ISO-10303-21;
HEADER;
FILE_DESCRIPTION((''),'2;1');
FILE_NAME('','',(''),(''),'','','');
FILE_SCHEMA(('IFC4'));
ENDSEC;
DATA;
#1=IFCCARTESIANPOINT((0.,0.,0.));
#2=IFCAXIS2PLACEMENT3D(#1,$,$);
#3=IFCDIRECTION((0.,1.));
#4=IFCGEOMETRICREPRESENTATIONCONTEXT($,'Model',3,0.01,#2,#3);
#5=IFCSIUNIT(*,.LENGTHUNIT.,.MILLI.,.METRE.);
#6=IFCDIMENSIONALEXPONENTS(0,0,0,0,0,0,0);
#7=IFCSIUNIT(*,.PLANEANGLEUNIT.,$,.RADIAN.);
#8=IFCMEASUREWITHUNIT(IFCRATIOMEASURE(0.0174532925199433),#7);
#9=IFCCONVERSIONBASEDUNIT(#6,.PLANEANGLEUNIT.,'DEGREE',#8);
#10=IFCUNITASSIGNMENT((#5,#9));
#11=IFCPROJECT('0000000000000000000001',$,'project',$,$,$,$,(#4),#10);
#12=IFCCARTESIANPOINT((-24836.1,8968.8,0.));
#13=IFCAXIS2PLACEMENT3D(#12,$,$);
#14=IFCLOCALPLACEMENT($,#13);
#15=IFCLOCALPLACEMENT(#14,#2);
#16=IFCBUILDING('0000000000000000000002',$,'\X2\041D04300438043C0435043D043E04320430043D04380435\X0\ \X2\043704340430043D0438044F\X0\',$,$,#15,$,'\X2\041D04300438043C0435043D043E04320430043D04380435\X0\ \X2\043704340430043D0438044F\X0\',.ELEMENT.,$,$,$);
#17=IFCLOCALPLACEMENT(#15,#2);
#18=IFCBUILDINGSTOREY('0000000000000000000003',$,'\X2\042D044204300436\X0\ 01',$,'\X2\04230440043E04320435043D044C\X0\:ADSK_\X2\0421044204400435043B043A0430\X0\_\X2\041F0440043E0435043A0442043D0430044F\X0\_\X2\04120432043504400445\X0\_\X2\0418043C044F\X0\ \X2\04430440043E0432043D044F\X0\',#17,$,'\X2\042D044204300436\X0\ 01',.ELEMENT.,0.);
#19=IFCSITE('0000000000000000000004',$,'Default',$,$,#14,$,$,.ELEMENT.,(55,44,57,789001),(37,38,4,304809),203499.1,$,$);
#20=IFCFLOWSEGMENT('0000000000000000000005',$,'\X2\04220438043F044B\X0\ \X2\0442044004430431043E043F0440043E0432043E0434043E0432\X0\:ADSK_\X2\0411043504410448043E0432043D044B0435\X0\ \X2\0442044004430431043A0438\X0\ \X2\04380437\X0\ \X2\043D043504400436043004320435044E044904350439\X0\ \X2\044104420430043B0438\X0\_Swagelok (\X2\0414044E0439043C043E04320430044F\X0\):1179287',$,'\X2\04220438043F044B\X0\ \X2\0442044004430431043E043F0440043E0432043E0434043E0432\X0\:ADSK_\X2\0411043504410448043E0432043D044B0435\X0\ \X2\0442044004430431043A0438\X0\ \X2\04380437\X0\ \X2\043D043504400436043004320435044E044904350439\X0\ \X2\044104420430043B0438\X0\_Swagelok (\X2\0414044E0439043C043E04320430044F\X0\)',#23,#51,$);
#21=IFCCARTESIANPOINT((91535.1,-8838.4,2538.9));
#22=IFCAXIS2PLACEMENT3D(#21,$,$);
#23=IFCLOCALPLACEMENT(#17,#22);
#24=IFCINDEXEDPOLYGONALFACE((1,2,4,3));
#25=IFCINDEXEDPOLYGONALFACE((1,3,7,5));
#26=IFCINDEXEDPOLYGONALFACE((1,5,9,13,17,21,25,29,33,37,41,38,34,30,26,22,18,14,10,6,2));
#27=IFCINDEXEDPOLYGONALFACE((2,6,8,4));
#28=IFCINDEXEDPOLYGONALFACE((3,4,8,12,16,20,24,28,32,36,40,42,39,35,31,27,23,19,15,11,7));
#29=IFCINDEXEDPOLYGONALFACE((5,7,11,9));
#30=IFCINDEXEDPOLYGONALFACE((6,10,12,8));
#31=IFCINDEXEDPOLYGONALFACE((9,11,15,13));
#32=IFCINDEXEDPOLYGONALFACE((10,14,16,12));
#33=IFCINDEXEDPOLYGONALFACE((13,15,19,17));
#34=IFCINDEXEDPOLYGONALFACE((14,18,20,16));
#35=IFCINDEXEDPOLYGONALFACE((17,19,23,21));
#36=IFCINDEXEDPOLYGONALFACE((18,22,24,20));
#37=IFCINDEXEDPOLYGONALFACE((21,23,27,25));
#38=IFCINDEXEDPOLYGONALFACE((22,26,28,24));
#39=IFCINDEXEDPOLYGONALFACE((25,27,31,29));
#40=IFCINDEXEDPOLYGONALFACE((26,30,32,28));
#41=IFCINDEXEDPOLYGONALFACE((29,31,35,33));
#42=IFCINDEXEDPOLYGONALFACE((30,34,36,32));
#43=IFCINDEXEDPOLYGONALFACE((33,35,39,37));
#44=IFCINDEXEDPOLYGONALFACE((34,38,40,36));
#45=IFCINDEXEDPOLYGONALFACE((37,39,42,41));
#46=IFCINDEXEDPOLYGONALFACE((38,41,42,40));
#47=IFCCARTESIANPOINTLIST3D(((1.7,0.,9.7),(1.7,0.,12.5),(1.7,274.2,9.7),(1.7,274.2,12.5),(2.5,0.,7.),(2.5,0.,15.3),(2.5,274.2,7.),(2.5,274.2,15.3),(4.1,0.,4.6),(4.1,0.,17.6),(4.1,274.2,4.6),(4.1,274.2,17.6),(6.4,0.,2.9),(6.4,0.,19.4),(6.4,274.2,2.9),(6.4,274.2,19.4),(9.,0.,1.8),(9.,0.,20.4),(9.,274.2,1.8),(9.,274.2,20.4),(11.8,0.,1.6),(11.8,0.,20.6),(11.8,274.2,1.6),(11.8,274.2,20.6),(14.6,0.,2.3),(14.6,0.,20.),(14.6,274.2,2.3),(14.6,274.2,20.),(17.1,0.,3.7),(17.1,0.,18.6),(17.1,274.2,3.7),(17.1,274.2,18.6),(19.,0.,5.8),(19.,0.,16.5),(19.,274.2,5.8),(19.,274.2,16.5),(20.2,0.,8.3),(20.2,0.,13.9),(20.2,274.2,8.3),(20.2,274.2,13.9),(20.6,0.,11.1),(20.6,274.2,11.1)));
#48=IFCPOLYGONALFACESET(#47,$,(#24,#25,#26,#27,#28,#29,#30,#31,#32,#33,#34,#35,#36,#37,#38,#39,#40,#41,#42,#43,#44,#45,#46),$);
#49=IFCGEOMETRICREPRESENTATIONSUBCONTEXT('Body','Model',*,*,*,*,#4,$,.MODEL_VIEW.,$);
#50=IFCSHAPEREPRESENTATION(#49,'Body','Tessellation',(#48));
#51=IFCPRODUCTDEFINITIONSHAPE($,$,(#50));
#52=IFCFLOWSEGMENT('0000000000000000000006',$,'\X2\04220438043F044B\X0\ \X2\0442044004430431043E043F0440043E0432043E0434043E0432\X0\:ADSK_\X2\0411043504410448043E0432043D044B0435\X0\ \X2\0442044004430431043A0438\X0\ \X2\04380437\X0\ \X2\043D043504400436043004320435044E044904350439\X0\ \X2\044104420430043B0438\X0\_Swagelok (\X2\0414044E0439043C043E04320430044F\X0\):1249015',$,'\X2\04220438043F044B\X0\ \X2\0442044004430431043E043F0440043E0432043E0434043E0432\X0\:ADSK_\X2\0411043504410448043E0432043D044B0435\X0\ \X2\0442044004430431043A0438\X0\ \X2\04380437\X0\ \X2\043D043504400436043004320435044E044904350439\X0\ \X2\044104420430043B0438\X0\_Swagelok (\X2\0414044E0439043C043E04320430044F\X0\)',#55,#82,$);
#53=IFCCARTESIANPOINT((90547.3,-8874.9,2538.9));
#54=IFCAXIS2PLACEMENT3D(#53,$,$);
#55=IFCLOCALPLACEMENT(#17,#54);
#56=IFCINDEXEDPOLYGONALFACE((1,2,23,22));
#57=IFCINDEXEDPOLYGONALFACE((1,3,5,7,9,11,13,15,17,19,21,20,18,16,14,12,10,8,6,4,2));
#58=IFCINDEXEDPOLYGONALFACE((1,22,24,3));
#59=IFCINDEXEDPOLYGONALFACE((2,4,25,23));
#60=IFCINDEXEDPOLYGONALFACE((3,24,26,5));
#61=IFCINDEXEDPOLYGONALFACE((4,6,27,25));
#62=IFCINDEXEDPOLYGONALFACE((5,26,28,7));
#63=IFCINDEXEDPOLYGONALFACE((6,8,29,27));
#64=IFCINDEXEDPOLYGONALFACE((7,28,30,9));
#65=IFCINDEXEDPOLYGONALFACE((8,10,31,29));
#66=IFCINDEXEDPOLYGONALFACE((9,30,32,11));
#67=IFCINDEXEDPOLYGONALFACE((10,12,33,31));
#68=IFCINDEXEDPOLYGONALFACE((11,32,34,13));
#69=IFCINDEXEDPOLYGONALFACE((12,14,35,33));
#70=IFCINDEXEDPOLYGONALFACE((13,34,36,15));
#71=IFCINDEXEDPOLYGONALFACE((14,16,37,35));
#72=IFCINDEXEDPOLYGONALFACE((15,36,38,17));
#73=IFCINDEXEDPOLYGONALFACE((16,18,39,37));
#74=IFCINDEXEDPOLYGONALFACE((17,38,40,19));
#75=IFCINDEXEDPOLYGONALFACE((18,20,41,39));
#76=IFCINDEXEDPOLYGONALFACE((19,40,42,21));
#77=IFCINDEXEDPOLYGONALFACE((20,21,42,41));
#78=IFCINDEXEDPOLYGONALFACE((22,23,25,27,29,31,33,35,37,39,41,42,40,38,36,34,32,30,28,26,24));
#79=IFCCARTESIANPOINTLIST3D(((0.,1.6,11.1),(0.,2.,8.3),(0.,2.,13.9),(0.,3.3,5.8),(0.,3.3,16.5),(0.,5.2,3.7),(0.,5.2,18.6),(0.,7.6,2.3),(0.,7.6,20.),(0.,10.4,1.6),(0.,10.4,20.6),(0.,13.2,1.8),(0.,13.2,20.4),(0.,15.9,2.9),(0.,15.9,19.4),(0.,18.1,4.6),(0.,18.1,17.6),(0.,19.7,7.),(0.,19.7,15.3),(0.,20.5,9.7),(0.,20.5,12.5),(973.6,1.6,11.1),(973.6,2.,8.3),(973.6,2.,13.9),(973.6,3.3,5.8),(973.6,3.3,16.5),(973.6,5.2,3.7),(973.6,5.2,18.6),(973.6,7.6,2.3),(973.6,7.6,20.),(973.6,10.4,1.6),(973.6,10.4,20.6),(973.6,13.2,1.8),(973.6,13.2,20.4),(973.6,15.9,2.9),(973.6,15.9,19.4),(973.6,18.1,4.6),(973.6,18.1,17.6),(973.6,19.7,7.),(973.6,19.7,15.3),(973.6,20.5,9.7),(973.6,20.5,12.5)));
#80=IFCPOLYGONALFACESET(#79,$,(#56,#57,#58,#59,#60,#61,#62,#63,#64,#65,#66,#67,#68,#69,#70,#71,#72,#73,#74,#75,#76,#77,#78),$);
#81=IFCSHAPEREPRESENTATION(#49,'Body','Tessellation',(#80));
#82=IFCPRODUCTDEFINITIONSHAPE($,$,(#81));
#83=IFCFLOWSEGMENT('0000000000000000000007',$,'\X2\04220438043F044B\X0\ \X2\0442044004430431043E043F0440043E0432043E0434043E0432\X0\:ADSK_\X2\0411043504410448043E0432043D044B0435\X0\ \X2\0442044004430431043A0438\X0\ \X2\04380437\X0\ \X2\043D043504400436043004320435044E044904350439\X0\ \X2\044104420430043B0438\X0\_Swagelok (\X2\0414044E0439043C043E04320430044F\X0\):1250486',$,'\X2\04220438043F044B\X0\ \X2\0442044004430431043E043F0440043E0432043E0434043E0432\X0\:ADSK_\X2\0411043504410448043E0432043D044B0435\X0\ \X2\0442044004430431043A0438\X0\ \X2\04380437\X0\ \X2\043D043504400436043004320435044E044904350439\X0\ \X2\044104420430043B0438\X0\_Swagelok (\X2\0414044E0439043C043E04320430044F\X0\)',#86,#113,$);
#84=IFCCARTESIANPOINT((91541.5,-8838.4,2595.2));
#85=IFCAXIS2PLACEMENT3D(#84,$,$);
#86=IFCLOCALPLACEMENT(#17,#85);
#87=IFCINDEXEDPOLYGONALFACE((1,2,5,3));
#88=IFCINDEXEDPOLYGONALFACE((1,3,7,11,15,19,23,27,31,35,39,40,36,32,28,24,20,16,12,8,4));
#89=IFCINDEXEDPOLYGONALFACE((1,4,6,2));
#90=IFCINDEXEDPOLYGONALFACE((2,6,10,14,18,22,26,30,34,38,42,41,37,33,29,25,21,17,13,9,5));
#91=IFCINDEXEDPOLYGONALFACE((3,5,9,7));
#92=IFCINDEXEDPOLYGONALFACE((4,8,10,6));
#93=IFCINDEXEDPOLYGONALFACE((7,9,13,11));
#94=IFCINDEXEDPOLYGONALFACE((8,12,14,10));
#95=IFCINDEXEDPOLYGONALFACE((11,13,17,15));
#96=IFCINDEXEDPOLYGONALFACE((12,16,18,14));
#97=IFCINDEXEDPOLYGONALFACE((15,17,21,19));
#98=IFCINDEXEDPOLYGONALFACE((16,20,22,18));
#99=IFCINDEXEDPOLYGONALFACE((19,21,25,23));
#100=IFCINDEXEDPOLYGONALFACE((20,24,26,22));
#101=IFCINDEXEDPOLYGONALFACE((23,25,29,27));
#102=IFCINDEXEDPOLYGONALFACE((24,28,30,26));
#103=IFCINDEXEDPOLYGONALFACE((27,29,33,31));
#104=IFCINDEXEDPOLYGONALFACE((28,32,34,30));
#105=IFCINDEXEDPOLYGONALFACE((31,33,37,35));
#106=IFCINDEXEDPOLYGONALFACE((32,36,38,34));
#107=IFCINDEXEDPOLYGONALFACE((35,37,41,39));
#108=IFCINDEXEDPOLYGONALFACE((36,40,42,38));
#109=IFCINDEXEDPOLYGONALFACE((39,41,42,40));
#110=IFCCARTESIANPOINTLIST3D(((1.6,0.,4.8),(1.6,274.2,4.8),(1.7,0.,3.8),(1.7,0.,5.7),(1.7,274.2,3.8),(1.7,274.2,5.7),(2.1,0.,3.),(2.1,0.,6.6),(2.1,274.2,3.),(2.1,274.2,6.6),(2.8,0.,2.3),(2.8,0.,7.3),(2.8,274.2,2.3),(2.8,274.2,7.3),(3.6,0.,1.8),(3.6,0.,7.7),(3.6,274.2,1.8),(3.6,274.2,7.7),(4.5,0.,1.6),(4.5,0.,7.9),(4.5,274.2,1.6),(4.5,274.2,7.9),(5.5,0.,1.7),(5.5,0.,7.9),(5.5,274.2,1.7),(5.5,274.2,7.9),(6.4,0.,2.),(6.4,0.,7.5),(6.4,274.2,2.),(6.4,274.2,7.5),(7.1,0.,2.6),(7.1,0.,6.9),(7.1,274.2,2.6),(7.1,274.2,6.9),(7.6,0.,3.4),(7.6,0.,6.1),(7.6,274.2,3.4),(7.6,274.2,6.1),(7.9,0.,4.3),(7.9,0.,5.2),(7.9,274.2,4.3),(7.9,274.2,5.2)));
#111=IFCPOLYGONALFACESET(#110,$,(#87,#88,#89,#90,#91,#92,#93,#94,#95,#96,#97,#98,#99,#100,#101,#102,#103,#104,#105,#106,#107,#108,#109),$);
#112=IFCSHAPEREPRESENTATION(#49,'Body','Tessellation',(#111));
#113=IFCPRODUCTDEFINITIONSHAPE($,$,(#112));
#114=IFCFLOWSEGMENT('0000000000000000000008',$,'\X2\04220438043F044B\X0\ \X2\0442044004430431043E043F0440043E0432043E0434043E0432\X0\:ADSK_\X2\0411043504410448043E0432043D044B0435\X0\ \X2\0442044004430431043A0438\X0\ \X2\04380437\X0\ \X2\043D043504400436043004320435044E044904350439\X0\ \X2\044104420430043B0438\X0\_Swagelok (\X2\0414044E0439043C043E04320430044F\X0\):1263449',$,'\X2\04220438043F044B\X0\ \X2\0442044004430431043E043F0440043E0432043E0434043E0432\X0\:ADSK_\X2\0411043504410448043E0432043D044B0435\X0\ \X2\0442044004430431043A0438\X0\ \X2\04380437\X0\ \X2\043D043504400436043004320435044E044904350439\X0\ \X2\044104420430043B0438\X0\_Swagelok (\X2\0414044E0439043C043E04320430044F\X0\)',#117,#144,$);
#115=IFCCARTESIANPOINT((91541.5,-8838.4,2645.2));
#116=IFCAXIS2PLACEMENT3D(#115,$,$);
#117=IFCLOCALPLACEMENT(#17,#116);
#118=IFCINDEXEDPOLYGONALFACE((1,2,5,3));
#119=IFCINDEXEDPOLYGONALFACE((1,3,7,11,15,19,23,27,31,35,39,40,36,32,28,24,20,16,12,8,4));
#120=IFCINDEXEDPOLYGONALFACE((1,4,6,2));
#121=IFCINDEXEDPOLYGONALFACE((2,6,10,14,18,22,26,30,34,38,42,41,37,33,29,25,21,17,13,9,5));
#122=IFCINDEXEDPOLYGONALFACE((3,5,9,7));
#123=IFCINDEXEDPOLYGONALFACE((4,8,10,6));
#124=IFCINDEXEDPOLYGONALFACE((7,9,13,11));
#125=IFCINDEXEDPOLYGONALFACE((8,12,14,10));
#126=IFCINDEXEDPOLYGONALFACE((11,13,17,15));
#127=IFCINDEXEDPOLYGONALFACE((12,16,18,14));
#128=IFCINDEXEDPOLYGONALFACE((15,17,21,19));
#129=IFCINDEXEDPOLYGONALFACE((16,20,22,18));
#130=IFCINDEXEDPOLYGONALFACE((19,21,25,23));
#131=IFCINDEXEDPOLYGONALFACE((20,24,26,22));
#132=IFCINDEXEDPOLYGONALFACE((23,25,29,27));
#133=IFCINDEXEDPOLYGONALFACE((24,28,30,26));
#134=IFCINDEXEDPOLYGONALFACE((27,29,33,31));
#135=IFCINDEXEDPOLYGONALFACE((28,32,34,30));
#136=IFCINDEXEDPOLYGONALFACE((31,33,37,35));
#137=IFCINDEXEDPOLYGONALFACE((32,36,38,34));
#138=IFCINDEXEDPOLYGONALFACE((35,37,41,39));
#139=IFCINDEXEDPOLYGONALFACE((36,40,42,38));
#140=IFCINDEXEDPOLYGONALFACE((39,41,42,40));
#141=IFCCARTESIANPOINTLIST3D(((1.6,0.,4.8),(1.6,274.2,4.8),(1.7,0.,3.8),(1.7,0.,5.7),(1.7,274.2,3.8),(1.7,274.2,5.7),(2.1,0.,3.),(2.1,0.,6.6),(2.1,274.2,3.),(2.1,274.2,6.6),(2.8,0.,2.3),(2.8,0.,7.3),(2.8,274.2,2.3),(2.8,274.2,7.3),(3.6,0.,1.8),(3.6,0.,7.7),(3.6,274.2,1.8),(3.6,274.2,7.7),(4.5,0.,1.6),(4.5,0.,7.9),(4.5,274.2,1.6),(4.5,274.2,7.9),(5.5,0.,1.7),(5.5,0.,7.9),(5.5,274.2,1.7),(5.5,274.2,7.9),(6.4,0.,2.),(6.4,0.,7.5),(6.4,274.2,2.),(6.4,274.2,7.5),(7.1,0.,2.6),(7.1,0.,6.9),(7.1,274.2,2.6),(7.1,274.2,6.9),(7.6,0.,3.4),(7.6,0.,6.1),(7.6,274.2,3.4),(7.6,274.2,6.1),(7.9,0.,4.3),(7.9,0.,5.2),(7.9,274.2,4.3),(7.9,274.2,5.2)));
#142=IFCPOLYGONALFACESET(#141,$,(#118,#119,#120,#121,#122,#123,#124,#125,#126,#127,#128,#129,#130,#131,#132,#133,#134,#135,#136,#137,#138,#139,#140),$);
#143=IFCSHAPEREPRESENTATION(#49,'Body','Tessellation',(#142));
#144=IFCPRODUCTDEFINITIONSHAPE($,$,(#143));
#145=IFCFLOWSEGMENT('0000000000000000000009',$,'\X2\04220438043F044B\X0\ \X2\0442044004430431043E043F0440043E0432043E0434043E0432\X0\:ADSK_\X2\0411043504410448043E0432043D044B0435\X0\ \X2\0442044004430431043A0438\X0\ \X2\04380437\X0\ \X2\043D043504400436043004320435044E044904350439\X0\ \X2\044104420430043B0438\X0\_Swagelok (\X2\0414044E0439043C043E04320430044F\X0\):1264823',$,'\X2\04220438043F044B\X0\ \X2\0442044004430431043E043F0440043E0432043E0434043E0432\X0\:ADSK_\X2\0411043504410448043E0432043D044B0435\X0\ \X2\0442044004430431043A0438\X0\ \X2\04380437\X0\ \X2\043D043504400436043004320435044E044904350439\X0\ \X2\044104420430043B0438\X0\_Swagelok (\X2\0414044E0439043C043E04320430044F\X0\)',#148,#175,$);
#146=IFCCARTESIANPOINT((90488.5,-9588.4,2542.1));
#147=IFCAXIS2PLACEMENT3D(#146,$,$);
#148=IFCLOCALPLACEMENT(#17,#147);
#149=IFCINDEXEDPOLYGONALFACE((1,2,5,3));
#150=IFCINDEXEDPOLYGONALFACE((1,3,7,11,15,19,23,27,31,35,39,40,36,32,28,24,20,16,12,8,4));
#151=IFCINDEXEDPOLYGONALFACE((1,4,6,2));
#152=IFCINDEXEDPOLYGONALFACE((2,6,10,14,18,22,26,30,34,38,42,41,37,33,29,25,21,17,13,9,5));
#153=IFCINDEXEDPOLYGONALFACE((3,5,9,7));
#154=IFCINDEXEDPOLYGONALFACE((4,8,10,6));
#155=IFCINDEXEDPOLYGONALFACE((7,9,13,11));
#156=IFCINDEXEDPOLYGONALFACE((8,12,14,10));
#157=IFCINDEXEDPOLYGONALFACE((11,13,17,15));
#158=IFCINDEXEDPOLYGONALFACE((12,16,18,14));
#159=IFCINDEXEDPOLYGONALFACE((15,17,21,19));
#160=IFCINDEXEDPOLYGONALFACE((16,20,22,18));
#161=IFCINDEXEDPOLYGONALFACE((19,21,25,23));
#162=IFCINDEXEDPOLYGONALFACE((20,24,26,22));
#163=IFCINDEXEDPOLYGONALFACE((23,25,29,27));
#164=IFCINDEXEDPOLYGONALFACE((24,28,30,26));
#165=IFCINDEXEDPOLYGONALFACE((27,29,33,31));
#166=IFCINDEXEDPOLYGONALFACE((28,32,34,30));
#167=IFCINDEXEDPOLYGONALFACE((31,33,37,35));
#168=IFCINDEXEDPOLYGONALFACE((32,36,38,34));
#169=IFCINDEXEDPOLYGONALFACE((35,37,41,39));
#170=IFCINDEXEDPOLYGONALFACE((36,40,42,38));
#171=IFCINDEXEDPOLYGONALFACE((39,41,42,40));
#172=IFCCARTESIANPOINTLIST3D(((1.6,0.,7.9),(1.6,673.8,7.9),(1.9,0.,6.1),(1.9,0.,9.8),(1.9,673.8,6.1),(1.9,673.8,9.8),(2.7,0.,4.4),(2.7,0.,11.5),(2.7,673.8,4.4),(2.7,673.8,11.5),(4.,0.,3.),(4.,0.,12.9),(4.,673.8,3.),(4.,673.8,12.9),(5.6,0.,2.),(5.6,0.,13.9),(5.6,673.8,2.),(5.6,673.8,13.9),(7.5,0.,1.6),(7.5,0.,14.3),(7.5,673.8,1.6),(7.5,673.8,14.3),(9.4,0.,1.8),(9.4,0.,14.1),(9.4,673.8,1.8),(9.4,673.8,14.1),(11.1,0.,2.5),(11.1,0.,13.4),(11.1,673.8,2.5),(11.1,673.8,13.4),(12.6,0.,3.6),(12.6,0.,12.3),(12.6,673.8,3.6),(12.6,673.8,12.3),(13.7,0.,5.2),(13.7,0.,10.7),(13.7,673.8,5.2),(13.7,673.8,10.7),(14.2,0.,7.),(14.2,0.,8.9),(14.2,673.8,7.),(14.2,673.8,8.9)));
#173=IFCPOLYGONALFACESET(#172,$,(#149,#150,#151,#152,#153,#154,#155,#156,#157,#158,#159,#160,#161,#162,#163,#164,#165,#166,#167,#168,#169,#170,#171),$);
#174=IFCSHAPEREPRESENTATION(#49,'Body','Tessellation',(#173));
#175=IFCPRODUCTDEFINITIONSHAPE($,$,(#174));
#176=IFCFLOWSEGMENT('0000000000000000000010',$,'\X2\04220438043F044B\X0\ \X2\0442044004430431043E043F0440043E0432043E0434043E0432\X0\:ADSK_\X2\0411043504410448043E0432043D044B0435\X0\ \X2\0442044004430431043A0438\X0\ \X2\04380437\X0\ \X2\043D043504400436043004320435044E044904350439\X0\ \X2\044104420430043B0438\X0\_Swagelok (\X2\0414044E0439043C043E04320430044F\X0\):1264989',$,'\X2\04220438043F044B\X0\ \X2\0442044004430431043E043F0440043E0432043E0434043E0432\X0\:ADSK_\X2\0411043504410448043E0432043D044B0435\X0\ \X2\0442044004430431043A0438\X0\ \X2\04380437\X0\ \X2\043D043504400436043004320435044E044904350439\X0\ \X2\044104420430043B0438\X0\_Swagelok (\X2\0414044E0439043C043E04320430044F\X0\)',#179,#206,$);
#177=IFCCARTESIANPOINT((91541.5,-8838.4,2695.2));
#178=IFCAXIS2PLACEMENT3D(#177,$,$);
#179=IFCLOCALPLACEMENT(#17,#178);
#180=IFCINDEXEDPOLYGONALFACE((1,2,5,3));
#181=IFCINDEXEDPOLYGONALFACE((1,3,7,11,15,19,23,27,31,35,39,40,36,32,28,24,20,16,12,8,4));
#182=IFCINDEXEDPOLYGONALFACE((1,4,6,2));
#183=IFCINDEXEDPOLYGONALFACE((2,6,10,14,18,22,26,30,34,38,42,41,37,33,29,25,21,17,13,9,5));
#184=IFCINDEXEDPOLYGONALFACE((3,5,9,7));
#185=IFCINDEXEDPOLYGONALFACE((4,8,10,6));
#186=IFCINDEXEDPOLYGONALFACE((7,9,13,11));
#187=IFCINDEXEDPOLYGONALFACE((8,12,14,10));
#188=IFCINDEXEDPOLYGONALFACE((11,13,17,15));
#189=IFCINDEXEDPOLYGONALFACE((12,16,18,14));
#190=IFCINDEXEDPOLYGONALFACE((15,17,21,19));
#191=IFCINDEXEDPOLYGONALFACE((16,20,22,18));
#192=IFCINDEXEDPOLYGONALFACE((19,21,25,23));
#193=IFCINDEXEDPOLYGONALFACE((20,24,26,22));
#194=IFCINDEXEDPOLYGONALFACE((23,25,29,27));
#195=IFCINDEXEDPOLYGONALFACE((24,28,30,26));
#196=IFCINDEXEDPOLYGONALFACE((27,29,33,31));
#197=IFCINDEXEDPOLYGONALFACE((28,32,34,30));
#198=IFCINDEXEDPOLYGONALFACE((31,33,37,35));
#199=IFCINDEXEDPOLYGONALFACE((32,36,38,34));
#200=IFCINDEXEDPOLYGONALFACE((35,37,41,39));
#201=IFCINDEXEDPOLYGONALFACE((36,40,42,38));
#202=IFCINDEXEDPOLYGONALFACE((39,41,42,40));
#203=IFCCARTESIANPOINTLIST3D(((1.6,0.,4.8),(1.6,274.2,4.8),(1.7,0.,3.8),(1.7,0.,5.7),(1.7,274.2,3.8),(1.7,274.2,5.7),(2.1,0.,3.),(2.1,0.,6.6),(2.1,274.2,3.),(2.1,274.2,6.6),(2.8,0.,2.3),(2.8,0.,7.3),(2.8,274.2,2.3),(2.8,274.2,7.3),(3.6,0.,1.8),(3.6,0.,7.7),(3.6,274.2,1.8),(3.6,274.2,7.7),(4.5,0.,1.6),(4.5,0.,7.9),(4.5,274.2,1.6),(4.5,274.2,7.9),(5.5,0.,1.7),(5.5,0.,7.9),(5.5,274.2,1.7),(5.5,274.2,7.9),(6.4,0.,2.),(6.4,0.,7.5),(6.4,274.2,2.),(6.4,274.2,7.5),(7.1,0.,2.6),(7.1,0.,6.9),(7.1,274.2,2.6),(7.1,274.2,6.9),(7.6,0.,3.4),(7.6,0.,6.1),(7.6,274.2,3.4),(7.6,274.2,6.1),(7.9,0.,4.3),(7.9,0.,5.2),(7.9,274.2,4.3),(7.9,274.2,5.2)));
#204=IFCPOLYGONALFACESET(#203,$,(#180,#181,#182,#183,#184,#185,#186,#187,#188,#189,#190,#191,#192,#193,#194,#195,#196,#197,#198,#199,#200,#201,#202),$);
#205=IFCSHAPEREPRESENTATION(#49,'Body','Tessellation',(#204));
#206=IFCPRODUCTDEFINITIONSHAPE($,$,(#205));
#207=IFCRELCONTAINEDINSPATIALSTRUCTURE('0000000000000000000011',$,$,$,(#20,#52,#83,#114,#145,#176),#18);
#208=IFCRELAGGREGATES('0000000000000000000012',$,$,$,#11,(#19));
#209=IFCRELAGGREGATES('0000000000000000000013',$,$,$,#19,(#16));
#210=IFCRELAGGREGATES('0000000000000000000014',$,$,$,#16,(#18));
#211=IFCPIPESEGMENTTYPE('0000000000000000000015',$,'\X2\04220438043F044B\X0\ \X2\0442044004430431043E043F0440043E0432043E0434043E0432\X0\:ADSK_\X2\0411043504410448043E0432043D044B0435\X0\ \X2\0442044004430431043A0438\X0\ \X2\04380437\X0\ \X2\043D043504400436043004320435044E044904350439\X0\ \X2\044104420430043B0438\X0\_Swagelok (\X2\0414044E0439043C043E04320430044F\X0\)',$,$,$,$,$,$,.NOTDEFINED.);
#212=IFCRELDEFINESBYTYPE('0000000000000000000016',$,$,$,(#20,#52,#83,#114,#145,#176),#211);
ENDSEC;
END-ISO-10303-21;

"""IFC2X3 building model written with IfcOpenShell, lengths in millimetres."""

from ifc_helpers import new_model, entity, si_unit, converted_unit, direction, frame, origin, origin_2d_with_axis, place, context, subcontext, project, spatial, circle, extrude, type_object, element, save


model = new_model("IFC2X3")

# Units and contexts
model_context = context("Model", 3, precision=0.01, world=origin(), true_north=direction((0.0, 1.0)))
body_context = subcontext(model_context, "Body", "Model", "MODEL_VIEW")
ifc_project = project(units=[si_unit("LENGTHUNIT", "METRE", prefix="MILLI"), converted_unit("PLANEANGLEUNIT", "DEGREE", entity("IfcRatioMeasure", 0.0174532925199433), si_unit("PLANEANGLEUNIT", "RADIAN"), dimensions=[0, 0, 0, 0, 0, 0, 0])], contexts=[model_context])

# Site, building, storey
site_placement = place(None, frame((-24836.1, 8968.8, 0.0)))
site = spatial("IfcSite", under=ifc_project, at=site_placement, Name="Default", CompositionType="ELEMENT", RefLatitude=(55, 44, 57, 789001), RefLongitude=(37, 38, 4, 304809), RefElevation=203499.1)
building_placement = place(site_placement, origin())
building = spatial("IfcBuilding", under=site, at=building_placement, Name="Наименование здания", LongName="Наименование здания", CompositionType="ELEMENT")
storey_placement = place(building_placement, origin())
storey = spatial("IfcBuildingStorey", under=building, at=storey_placement, Name="Этаж 01", ObjectType="Уровень:ADSK_Стрелка_Проектная_Вверх_Имя уровня", LongName="Этаж 01", CompositionType="ELEMENT", Elevation=0.0)

# Flow segments
pipe_segment_type_1 = type_object("IfcPipeSegmentType", Name="Типы трубопроводов:ADSK_Бесшовные трубки из нержавеющей стали_Swagelok (Дюймовая)", PredefinedType="NOTDEFINED")
flow_segment_1_placement = place(storey_placement, frame((91535.1, -8838.4, 2538.9)))
element("IfcFlowSegment", 1, at=flow_segment_1_placement, inside=storey, type_object=pipe_segment_type_1, Name="Типы трубопроводов:ADSK_Бесшовные трубки из нержавеющей стали_Swagelok (Дюймовая):1179287", ObjectType="Типы трубопроводов:ADSK_Бесшовные трубки из нержавеющей стали_Swagelok (Дюймовая)", context=body_context, shape_type="SweptSolid", body=[
    extrude(circle(Radius=9.5, at=origin_2d_with_axis()), frame((11.1, 0.0, 11.1), z_axis=(0.0, 1.0, 0.0), x_axis=(1.0, 0.0, 0.0)), (0.0, 0.0, 1.0), 274.2),
])
flow_segment_2_placement = place(storey_placement, frame((90547.3, -8874.9, 2538.9)))
element("IfcFlowSegment", 2, at=flow_segment_2_placement, inside=storey, type_object=pipe_segment_type_1, Name="Типы трубопроводов:ADSK_Бесшовные трубки из нержавеющей стали_Swagelok (Дюймовая):1249015", ObjectType="Типы трубопроводов:ADSK_Бесшовные трубки из нержавеющей стали_Swagelok (Дюймовая)", context=body_context, shape_type="SweptSolid", body=[
    extrude(circle(Radius=9.5, at=origin_2d_with_axis()), frame((0.0, 11.1, 11.1), z_axis=(1.0, 0.0, 0.0), x_axis=(0.0, -1.0, 0.0)), (0.0, 0.0, 1.0), 973.6),
])
flow_segment_3_placement = place(storey_placement, frame((91541.5, -8838.4, 2595.2)))
element("IfcFlowSegment", 3, at=flow_segment_3_placement, inside=storey, type_object=pipe_segment_type_1, Name="Типы трубопроводов:ADSK_Бесшовные трубки из нержавеющей стали_Swagelok (Дюймовая):1250486", ObjectType="Типы трубопроводов:ADSK_Бесшовные трубки из нержавеющей стали_Swagelok (Дюймовая)", context=body_context, shape_type="SweptSolid", body=[
    extrude(circle(Radius=3.2, at=origin_2d_with_axis()), frame((4.8, 0.0, 4.8), z_axis=(0.0, 1.0, 0.0), x_axis=(-1.0, 0.0, 0.0)), (0.0, 0.0, 1.0), 274.2),
])
flow_segment_4_placement = place(storey_placement, frame((91541.5, -8838.4, 2645.2)))
element("IfcFlowSegment", 4, at=flow_segment_4_placement, inside=storey, type_object=pipe_segment_type_1, Name="Типы трубопроводов:ADSK_Бесшовные трубки из нержавеющей стали_Swagelok (Дюймовая):1263449", ObjectType="Типы трубопроводов:ADSK_Бесшовные трубки из нержавеющей стали_Swagelok (Дюймовая)", context=body_context, shape_type="SweptSolid", body=[
    extrude(circle(Radius=3.2, at=origin_2d_with_axis()), frame((4.8, 0.0, 4.8), z_axis=(0.0, 1.0, 0.0), x_axis=(-1.0, 0.0, 0.0)), (0.0, 0.0, 1.0), 274.2),
])
flow_segment_5_placement = place(storey_placement, frame((90488.5, -9588.4, 2542.1)))
element("IfcFlowSegment", 5, at=flow_segment_5_placement, inside=storey, type_object=pipe_segment_type_1, Name="Типы трубопроводов:ADSK_Бесшовные трубки из нержавеющей стали_Swagelok (Дюймовая):1264823", ObjectType="Типы трубопроводов:ADSK_Бесшовные трубки из нержавеющей стали_Swagelok (Дюймовая)", context=body_context, shape_type="SweptSolid", body=[
    extrude(circle(Radius=6.3, at=origin_2d_with_axis()), frame((8.0, 0.0, 8.0), z_axis=(0.0, 1.0, 0.0), x_axis=(-1.0, 0.0, 0.0)), (0.0, 0.0, 1.0), 673.8),
])
flow_segment_6_placement = place(storey_placement, frame((91541.5, -8838.4, 2695.2)))
element("IfcFlowSegment", 6, at=flow_segment_6_placement, inside=storey, type_object=pipe_segment_type_1, Name="Типы трубопроводов:ADSK_Бесшовные трубки из нержавеющей стали_Swagelok (Дюймовая):1264989", ObjectType="Типы трубопроводов:ADSK_Бесшовные трубки из нержавеющей стали_Swagelok (Дюймовая)", context=body_context, shape_type="SweptSolid", body=[
    extrude(circle(Radius=3.2, at=origin_2d_with_axis()), frame((4.8, 0.0, 4.8), z_axis=(0.0, 1.0, 0.0), x_axis=(-1.0, 0.0, 0.0)), (0.0, 0.0, 1.0), 274.2),
])

save(model, "model.ifc")
